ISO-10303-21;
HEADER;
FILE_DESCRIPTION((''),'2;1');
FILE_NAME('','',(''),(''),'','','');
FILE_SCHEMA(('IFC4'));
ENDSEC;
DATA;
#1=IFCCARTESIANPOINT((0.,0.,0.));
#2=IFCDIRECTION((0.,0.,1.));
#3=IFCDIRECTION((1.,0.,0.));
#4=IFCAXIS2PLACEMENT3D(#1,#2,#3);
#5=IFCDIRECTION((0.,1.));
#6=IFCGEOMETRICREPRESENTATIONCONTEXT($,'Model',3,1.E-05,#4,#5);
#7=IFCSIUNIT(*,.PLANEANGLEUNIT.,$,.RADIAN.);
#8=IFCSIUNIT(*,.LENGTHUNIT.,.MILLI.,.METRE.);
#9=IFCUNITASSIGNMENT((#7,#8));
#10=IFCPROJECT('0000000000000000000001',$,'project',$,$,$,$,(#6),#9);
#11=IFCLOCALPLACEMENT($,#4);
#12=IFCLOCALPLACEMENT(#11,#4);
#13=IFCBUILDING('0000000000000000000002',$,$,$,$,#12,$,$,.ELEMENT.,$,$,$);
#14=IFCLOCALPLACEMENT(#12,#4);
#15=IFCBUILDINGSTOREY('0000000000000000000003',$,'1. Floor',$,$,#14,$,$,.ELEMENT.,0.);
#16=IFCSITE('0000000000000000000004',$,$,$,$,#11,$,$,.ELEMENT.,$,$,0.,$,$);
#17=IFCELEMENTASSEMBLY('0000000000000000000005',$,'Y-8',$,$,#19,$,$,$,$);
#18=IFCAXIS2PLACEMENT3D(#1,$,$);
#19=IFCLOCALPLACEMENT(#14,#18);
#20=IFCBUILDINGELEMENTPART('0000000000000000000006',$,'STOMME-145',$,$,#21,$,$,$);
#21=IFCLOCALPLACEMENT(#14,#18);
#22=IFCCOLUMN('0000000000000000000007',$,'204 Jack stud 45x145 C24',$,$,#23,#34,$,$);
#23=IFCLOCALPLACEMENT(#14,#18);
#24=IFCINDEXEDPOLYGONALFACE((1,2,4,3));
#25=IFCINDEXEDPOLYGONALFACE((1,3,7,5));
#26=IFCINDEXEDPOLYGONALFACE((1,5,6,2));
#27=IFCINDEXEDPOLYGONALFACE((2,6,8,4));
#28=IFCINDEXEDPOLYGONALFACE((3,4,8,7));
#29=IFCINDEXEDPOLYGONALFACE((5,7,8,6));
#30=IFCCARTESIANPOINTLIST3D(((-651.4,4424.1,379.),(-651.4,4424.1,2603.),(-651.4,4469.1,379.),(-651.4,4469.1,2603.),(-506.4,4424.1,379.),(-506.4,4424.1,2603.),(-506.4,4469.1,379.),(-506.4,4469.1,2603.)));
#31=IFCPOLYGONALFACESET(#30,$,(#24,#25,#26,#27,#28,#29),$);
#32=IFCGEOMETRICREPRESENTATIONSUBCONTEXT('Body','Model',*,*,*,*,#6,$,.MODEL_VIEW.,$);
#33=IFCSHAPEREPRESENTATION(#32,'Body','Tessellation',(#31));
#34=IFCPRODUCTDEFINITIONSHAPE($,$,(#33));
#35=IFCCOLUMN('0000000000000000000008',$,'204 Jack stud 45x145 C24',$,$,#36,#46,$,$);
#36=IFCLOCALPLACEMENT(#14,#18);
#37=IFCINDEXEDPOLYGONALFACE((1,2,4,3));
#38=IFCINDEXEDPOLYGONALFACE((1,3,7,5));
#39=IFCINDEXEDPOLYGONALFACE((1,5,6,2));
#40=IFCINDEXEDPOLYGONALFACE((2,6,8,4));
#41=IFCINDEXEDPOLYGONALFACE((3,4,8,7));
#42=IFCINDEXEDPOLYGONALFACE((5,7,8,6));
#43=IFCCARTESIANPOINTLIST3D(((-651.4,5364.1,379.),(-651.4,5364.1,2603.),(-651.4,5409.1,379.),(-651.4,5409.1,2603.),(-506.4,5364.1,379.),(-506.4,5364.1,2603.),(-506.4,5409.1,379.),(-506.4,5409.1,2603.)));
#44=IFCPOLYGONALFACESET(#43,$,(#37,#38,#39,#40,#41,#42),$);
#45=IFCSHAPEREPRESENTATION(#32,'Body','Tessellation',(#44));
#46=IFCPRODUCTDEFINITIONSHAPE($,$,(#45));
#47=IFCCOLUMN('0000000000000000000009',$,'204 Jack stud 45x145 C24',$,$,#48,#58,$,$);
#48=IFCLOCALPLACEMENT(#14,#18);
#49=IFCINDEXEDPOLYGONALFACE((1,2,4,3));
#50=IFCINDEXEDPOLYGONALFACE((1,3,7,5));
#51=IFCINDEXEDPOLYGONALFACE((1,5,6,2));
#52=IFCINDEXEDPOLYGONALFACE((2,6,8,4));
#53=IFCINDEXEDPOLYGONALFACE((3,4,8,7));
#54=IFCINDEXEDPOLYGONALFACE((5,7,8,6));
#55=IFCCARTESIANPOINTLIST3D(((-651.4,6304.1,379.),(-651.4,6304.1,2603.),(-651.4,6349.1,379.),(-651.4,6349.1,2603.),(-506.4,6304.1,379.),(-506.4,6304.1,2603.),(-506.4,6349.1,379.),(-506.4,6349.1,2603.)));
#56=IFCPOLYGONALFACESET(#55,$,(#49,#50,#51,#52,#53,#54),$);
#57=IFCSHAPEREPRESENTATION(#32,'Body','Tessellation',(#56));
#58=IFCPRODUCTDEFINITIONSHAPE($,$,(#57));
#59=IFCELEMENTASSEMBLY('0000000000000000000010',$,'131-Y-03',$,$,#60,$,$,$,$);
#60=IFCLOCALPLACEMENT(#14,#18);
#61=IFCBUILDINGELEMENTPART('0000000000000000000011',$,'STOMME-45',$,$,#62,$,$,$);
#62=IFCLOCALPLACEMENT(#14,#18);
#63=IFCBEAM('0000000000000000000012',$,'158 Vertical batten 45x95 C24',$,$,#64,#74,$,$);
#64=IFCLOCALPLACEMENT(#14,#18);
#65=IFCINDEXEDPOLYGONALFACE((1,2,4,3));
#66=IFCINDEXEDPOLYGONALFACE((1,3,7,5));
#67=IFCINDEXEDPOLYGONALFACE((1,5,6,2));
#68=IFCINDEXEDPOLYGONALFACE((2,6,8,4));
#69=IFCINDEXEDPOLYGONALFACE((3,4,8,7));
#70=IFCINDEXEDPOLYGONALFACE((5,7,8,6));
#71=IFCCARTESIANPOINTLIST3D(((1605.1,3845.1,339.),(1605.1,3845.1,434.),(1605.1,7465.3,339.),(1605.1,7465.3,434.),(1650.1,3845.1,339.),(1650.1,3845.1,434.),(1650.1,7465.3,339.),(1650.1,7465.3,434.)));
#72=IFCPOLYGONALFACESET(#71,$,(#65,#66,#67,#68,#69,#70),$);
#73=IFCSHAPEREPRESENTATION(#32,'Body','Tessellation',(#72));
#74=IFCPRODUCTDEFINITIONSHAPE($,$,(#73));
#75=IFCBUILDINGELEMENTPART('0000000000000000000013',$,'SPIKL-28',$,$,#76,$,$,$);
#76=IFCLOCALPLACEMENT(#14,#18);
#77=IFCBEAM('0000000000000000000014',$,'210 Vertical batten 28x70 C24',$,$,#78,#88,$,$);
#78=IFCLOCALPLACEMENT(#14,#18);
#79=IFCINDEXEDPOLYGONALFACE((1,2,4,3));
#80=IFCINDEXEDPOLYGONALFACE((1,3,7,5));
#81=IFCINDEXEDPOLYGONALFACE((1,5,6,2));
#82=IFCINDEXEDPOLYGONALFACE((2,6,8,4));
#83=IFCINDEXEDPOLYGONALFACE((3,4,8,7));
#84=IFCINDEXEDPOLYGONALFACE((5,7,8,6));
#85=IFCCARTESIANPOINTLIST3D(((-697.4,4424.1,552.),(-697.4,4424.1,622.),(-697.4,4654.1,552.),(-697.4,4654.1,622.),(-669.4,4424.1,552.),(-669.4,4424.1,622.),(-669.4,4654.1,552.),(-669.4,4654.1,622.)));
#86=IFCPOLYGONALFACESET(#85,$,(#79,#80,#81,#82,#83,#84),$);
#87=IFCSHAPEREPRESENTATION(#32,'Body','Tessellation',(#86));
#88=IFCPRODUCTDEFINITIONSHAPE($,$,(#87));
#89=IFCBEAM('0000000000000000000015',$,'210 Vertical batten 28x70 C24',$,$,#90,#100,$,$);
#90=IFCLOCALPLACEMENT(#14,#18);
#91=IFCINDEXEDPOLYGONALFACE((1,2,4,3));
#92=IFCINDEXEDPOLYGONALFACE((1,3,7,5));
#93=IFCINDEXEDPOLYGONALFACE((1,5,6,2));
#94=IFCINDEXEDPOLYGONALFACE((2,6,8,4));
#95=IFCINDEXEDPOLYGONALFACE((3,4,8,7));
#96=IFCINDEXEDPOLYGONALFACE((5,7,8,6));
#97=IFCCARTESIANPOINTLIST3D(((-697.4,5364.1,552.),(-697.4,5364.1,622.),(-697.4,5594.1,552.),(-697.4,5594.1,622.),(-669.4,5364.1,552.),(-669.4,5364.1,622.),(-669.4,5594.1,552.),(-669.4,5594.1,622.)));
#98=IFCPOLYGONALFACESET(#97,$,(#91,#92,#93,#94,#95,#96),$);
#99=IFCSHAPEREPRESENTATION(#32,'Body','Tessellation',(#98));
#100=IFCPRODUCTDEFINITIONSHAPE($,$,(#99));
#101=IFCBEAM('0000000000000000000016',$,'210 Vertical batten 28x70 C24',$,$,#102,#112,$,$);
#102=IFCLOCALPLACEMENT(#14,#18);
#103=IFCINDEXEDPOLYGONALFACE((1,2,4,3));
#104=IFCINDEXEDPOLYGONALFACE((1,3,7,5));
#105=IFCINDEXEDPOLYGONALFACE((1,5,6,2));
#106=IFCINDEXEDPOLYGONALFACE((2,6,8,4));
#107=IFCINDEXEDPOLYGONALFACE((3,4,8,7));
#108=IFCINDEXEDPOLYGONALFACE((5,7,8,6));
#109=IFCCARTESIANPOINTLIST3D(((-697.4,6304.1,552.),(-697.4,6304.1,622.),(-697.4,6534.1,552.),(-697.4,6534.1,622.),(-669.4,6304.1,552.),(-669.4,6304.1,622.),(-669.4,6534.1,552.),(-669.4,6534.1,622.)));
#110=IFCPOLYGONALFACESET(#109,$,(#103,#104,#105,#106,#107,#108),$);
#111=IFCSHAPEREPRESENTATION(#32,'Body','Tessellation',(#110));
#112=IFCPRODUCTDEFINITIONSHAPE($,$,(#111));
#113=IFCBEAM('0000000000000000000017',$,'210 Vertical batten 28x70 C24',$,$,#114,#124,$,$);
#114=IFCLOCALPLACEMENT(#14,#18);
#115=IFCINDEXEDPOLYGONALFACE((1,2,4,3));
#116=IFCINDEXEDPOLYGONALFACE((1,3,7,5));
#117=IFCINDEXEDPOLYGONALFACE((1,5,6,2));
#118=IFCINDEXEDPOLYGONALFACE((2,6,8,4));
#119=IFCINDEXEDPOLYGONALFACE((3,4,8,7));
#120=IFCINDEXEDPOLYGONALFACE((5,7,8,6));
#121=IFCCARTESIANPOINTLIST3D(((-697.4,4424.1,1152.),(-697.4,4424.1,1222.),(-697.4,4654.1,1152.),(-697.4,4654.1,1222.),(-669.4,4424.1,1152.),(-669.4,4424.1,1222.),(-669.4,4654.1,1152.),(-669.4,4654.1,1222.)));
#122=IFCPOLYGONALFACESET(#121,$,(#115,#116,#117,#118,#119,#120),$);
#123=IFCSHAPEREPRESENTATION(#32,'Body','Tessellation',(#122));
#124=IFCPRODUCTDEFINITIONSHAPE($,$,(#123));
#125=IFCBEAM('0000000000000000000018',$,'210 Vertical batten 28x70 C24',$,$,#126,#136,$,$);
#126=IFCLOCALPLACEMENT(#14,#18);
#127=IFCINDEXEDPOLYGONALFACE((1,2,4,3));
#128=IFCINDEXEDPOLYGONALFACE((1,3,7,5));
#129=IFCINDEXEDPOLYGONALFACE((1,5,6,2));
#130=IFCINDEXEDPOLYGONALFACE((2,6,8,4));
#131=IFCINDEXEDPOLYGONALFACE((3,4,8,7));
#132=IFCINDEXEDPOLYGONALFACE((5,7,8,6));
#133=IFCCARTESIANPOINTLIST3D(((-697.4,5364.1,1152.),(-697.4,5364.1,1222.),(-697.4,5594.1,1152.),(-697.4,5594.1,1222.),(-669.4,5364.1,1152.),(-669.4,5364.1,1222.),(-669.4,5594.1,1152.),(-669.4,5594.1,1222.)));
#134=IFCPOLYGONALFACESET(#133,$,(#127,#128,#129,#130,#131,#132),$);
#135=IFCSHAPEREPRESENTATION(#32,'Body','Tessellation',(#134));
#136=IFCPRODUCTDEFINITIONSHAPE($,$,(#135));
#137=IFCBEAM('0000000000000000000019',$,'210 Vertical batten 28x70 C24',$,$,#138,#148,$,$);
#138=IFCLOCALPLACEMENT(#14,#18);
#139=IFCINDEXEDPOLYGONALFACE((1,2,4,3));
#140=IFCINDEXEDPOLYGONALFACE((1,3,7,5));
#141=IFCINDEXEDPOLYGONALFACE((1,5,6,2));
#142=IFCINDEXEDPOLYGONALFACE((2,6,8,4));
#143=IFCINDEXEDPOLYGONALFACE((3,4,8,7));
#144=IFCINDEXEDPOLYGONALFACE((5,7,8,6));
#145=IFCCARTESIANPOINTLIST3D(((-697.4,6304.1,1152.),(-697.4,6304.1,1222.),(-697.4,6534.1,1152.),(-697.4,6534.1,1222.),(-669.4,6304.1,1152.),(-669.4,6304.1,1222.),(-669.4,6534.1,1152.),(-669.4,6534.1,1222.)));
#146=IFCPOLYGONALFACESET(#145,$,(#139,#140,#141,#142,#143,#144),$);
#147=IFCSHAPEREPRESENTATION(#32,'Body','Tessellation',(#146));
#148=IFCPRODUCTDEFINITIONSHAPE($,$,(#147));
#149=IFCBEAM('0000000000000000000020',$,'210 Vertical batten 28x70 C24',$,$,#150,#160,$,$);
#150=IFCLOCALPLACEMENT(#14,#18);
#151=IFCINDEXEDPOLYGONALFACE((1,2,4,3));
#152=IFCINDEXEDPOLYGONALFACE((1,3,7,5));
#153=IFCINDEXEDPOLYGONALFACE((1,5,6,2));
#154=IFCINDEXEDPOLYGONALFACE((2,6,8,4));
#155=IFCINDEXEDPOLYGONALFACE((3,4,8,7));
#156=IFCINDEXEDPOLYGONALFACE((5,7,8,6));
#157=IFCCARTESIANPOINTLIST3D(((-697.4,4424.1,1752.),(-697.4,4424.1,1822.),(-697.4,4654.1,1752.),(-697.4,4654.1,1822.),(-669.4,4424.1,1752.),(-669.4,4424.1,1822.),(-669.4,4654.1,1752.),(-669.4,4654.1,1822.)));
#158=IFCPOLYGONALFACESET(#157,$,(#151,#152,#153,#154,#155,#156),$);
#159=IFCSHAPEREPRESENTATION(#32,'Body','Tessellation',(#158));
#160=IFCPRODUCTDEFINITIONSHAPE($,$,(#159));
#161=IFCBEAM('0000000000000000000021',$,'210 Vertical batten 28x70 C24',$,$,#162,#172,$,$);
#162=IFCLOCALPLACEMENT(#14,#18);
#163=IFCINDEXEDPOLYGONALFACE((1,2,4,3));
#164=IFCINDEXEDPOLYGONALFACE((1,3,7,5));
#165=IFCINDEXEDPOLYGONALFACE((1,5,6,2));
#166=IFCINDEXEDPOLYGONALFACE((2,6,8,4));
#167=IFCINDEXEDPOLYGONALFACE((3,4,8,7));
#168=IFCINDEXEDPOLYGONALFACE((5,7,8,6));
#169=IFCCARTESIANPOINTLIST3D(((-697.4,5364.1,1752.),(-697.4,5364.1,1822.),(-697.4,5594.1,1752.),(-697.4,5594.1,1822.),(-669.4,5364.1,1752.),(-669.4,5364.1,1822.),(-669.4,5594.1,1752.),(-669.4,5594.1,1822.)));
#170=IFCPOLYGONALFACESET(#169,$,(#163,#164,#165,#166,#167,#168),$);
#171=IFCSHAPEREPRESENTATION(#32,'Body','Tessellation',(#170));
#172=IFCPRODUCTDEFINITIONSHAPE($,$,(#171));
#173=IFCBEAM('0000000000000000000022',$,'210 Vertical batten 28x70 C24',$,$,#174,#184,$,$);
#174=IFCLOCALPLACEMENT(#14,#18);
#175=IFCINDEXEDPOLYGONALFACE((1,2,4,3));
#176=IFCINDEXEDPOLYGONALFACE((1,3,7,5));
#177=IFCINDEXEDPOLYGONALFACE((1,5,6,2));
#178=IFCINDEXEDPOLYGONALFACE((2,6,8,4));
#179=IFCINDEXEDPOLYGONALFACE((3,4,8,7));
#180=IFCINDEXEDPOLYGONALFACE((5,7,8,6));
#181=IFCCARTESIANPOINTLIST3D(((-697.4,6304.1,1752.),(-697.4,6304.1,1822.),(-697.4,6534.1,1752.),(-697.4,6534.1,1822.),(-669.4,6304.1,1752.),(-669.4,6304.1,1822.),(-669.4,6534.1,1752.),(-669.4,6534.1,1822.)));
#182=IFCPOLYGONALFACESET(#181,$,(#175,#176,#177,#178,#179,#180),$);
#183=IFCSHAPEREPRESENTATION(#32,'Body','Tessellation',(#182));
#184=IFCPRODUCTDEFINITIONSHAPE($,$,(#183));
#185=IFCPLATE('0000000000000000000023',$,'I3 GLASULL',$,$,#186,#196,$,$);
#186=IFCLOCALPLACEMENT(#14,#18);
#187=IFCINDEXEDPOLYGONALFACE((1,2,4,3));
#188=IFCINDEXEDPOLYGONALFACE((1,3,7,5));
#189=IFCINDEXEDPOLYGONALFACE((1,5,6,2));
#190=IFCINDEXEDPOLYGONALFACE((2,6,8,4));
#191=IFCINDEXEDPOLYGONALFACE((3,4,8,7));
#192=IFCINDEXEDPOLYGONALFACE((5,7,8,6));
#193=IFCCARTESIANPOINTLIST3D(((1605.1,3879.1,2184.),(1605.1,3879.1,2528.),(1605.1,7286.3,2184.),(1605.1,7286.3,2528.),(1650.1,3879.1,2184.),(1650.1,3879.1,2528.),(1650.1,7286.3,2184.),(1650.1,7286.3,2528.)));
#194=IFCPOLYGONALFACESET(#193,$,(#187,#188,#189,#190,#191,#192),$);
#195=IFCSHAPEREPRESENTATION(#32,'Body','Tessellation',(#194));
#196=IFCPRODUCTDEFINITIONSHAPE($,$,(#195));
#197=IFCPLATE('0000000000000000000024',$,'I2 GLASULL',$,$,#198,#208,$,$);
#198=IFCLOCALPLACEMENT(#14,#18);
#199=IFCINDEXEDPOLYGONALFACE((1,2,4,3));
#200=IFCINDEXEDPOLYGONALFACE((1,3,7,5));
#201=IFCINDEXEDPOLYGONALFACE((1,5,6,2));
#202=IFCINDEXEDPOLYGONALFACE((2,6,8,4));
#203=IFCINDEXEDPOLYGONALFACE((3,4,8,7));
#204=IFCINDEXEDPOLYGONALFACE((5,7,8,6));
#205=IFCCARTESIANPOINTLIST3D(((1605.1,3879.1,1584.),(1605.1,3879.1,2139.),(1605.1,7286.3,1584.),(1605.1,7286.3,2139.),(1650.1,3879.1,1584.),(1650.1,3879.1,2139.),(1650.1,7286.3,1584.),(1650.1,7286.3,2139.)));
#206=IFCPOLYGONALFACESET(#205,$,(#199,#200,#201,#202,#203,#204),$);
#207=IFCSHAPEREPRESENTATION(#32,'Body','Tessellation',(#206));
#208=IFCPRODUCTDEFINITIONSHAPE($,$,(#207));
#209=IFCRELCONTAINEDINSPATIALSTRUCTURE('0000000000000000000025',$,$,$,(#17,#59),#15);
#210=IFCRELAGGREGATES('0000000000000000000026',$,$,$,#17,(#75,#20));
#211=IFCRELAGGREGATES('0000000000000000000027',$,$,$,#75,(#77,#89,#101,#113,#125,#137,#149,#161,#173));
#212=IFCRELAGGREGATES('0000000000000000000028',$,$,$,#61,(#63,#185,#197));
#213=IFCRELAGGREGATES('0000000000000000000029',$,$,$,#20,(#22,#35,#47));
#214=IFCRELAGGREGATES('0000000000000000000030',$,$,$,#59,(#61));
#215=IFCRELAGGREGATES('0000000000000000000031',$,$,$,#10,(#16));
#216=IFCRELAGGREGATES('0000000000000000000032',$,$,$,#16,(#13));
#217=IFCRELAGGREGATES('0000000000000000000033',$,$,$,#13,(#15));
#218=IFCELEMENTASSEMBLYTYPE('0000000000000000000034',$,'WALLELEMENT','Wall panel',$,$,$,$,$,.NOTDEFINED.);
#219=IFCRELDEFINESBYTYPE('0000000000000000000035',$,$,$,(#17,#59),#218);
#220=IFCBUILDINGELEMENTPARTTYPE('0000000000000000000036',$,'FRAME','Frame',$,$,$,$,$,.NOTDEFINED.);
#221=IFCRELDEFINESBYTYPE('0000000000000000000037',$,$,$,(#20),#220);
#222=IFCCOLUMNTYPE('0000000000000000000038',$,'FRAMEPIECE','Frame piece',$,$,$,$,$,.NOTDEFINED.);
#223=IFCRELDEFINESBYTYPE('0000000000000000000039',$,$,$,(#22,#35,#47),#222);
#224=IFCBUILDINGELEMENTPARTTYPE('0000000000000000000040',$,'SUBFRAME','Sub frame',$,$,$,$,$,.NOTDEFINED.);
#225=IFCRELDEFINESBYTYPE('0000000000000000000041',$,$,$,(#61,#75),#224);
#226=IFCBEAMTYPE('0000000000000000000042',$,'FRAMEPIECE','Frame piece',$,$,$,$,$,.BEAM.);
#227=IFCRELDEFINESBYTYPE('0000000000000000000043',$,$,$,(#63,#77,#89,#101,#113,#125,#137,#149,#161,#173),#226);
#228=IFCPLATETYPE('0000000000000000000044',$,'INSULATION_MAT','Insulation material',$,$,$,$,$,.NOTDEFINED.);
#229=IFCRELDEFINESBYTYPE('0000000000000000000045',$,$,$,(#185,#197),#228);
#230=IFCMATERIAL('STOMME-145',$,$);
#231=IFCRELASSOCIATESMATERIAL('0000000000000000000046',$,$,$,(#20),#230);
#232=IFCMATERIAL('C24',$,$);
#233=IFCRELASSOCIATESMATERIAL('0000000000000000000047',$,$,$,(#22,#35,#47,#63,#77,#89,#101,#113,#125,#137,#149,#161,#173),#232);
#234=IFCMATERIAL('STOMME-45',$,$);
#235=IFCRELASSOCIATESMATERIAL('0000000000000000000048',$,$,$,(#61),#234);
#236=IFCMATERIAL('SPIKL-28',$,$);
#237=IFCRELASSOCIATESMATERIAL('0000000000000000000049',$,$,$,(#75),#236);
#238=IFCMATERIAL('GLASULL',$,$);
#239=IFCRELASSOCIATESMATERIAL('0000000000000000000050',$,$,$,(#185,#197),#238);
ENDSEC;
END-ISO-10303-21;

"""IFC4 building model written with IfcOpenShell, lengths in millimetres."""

from ifc_helpers import new_model, si_unit, direction, frame, origin_with_axes, origin_2d_with_axis, place, context, subcontext, project, spatial, rectangle, extrude, material, type_object, element, aggregate, save


model = new_model("IFC4")

# Units and contexts
model_context = context("Model", 3, precision=1e-05, world=origin_with_axes(), true_north=direction((0.0, 1.0)))
body_context = subcontext(model_context, "Body", "Model", "MODEL_VIEW")
ifc_project = project(units=[si_unit("PLANEANGLEUNIT", "RADIAN"), si_unit("LENGTHUNIT", "METRE", prefix="MILLI")], contexts=[model_context])

# Site, building, storey
site_placement = place(None, origin_with_axes())
site = spatial("IfcSite", under=ifc_project, at=site_placement, CompositionType="ELEMENT", RefElevation=0.0)
building_placement = place(site_placement, origin_with_axes())
building = spatial("IfcBuilding", under=site, at=building_placement, CompositionType="ELEMENT")
storey_placement = place(building_placement, origin_with_axes())
storey = spatial("IfcBuildingStorey", under=building, at=storey_placement, Name="1. Floor", CompositionType="ELEMENT", Elevation=0.0)

# Element assembly, building element part, columns
element_assembly_type = type_object("IfcElementAssemblyType", Name="WALLELEMENT", Description="Wall panel", PredefinedType="NOTDEFINED")
assembly_1_placement = place(storey_placement, origin_with_axes())
assembly_1 = element("IfcElementAssembly", 1, at=assembly_1_placement, inside=storey, type_object=element_assembly_type, Name="Y-8")
ifc_material_1 = material(Name="STOMME-145")
building_element_part_type_1 = type_object("IfcBuildingElementPartType", Name="FRAME", Description="Frame", PredefinedType="NOTDEFINED")
building_element_part_1_placement = place(storey_placement, origin_with_axes())
building_element_part_1 = element("IfcBuildingElementPart", 2, at=building_element_part_1_placement, type_object=building_element_part_type_1, material=ifc_material_1, Name="STOMME-145")
ifc_material_2 = material(Name="C24")
column_type = type_object("IfcColumnType", Name="FRAMEPIECE", Description="Frame piece", PredefinedType="NOTDEFINED")
column_1_placement = place(storey_placement, frame((-578.9, 4446.6, 379.0), z_axis=(0.0, 0.0, 1.0), x_axis=(0.0, 1.0, 0.0)))
column_1 = element("IfcColumn", 3, at=column_1_placement, type_object=column_type, material=ifc_material_2, Name="204 Jack stud 45x145 C24", context=body_context, shape_type="SweptSolid", body=[
    extrude(rectangle(XDim=45.0, YDim=145.0, at=origin_2d_with_axis()), origin_with_axes(), (0.0, 0.0, 1.0), 2224.0),
])
column_2_placement = place(storey_placement, frame((-578.9, 5386.6, 379.0), z_axis=(0.0, 0.0, 1.0), x_axis=(0.0, 1.0, 0.0)))
column_2 = element("IfcColumn", 4, at=column_2_placement, type_object=column_type, material=ifc_material_2, Name="204 Jack stud 45x145 C24", context=body_context, shape_type="SweptSolid", body=[
    extrude(rectangle(XDim=45.0, YDim=145.0, at=origin_2d_with_axis()), origin_with_axes(), (0.0, 0.0, 1.0), 2224.0),
])
column_3_placement = place(storey_placement, frame((-578.9, 6326.6, 379.0), z_axis=(0.0, 0.0, 1.0), x_axis=(0.0, 1.0, 0.0)))
column_3 = element("IfcColumn", 5, at=column_3_placement, type_object=column_type, material=ifc_material_2, Name="204 Jack stud 45x145 C24", context=body_context, shape_type="SweptSolid", body=[
    extrude(rectangle(XDim=45.0, YDim=145.0, at=origin_2d_with_axis()), origin_with_axes(), (0.0, 0.0, 1.0), 2224.0),
])

# Element assembly, building element part, beam
assembly_2_placement = place(storey_placement, origin_with_axes())
assembly_2 = element("IfcElementAssembly", 6, at=assembly_2_placement, inside=storey, type_object=element_assembly_type, Name="131-Y-03")
ifc_material_3 = material(Name="STOMME-45")
building_element_part_type_2 = type_object("IfcBuildingElementPartType", Name="SUBFRAME", Description="Sub frame", PredefinedType="NOTDEFINED")
building_element_part_2_placement = place(storey_placement, origin_with_axes())
building_element_part_2 = element("IfcBuildingElementPart", 7, at=building_element_part_2_placement, type_object=building_element_part_type_2, material=ifc_material_3, Name="STOMME-45")
beam_type = type_object("IfcBeamType", Name="FRAMEPIECE", Description="Frame piece", PredefinedType="BEAM")
beam_1_placement = place(storey_placement, frame((1627.6, 3845.1, 386.5), z_axis=(0.0, 1.0, 0.0), x_axis=(-1.0, 0.0, 0.0)))
beam_1 = element("IfcBeam", 8, at=beam_1_placement, type_object=beam_type, material=ifc_material_2, Name="158 Vertical batten 45x95 C24", context=body_context, shape_type="SweptSolid", body=[
    extrude(rectangle(XDim=45.0, YDim=95.0, at=origin_2d_with_axis()), origin_with_axes(), (0.0, 0.0, 1.0), 3620.2),
])

# Building element part
ifc_material_4 = material(Name="SPIKL-28")
building_element_part_3_placement = place(storey_placement, origin_with_axes())
building_element_part_3 = element("IfcBuildingElementPart", 9, at=building_element_part_3_placement, type_object=building_element_part_type_2, material=ifc_material_4, Name="SPIKL-28")
aggregate(assembly_1, [building_element_part_3, building_element_part_1])

# Beams
beam_2_placement = place(storey_placement, frame((-683.4, 4424.1, 587.0), z_axis=(0.0, 1.0, 0.0), x_axis=(-1.0, 0.0, 0.0)))
beam_2 = element("IfcBeam", 10, at=beam_2_placement, type_object=beam_type, material=ifc_material_2, Name="210 Vertical batten 28x70 C24", context=body_context, shape_type="SweptSolid", body=[
    extrude(rectangle(XDim=28.0, YDim=70.0, at=origin_2d_with_axis()), origin_with_axes(), (0.0, 0.0, 1.0), 230.0),
])
beam_3_placement = place(storey_placement, frame((-683.4, 5364.1, 587.0), z_axis=(0.0, 1.0, 0.0), x_axis=(-1.0, 0.0, 0.0)))
beam_3 = element("IfcBeam", 11, at=beam_3_placement, type_object=beam_type, material=ifc_material_2, Name="210 Vertical batten 28x70 C24", context=body_context, shape_type="SweptSolid", body=[
    extrude(rectangle(XDim=28.0, YDim=70.0, at=origin_2d_with_axis()), origin_with_axes(), (0.0, 0.0, 1.0), 230.0),
])
beam_4_placement = place(storey_placement, frame((-683.4, 6304.1, 587.0), z_axis=(0.0, 1.0, 0.0), x_axis=(-1.0, 0.0, 0.0)))
beam_4 = element("IfcBeam", 12, at=beam_4_placement, type_object=beam_type, material=ifc_material_2, Name="210 Vertical batten 28x70 C24", context=body_context, shape_type="SweptSolid", body=[
    extrude(rectangle(XDim=28.0, YDim=70.0, at=origin_2d_with_axis()), origin_with_axes(), (0.0, 0.0, 1.0), 230.0),
])
beam_5_placement = place(storey_placement, frame((-683.4, 4424.1, 1187.0), z_axis=(0.0, 1.0, 0.0), x_axis=(-1.0, 0.0, 0.0)))
beam_5 = element("IfcBeam", 13, at=beam_5_placement, type_object=beam_type, material=ifc_material_2, Name="210 Vertical batten 28x70 C24", context=body_context, shape_type="SweptSolid", body=[
    extrude(rectangle(XDim=28.0, YDim=70.0, at=origin_2d_with_axis()), origin_with_axes(), (0.0, 0.0, 1.0), 230.0),
])
beam_6_placement = place(storey_placement, frame((-683.4, 5364.1, 1187.0), z_axis=(0.0, 1.0, 0.0), x_axis=(-1.0, 0.0, 0.0)))
beam_6 = element("IfcBeam", 14, at=beam_6_placement, type_object=beam_type, material=ifc_material_2, Name="210 Vertical batten 28x70 C24", context=body_context, shape_type="SweptSolid", body=[
    extrude(rectangle(XDim=28.0, YDim=70.0, at=origin_2d_with_axis()), origin_with_axes(), (0.0, 0.0, 1.0), 230.0),
])
beam_7_placement = place(storey_placement, frame((-683.4, 6304.1, 1187.0), z_axis=(0.0, 1.0, 0.0), x_axis=(-1.0, 0.0, 0.0)))
beam_7 = element("IfcBeam", 15, at=beam_7_placement, type_object=beam_type, material=ifc_material_2, Name="210 Vertical batten 28x70 C24", context=body_context, shape_type="SweptSolid", body=[
    extrude(rectangle(XDim=28.0, YDim=70.0, at=origin_2d_with_axis()), origin_with_axes(), (0.0, 0.0, 1.0), 230.0),
])
beam_8_placement = place(storey_placement, frame((-683.4, 4424.1, 1787.0), z_axis=(0.0, 1.0, 0.0), x_axis=(-1.0, 0.0, 0.0)))
beam_8 = element("IfcBeam", 16, at=beam_8_placement, type_object=beam_type, material=ifc_material_2, Name="210 Vertical batten 28x70 C24", context=body_context, shape_type="SweptSolid", body=[
    extrude(rectangle(XDim=28.0, YDim=70.0, at=origin_2d_with_axis()), origin_with_axes(), (0.0, 0.0, 1.0), 230.0),
])
beam_9_placement = place(storey_placement, frame((-683.4, 5364.1, 1787.0), z_axis=(0.0, 1.0, 0.0), x_axis=(-1.0, 0.0, 0.0)))
beam_9 = element("IfcBeam", 17, at=beam_9_placement, type_object=beam_type, material=ifc_material_2, Name="210 Vertical batten 28x70 C24", context=body_context, shape_type="SweptSolid", body=[
    extrude(rectangle(XDim=28.0, YDim=70.0, at=origin_2d_with_axis()), origin_with_axes(), (0.0, 0.0, 1.0), 230.0),
])
beam_10_placement = place(storey_placement, frame((-683.4, 6304.1, 1787.0), z_axis=(0.0, 1.0, 0.0), x_axis=(-1.0, 0.0, 0.0)))
beam_10 = element("IfcBeam", 18, at=beam_10_placement, type_object=beam_type, material=ifc_material_2, Name="210 Vertical batten 28x70 C24", context=body_context, shape_type="SweptSolid", body=[
    extrude(rectangle(XDim=28.0, YDim=70.0, at=origin_2d_with_axis()), origin_with_axes(), (0.0, 0.0, 1.0), 230.0),
])
aggregate(building_element_part_3, [beam_2, beam_3, beam_4, beam_5, beam_6, beam_7, beam_8, beam_9, beam_10])

# Plates
ifc_material_5 = material(Name="GLASULL")
plate_type_1 = type_object("IfcPlateType", Name="INSULATION_MAT", Description="Insulation material", PredefinedType="NOTDEFINED")
plate_1_placement = place(storey_placement, frame((1605.1, 5582.7, 2356.0), z_axis=(-1.0, 0.0, 0.0), x_axis=(0.0, -1.0, 0.0)))
plate_1 = element("IfcPlate", 19, at=plate_1_placement, type_object=plate_type_1, material=ifc_material_5, Name="I3 GLASULL", context=body_context, shape_type="SweptSolid", body=[
    extrude(rectangle(XDim=45.0, YDim=3407.2, at=origin_2d_with_axis()), frame((0.0, -172.0, -22.5), z_axis=(0.0, 1.0, 0.0), x_axis=(0.0, 0.0, 1.0)), (0.0, 0.0, 1.0), 344.0),
])
plate_2_placement = place(storey_placement, frame((1605.1, 5582.7, 1861.5), z_axis=(-1.0, 0.0, 0.0), x_axis=(0.0, -1.0, 0.0)))
plate_2 = element("IfcPlate", 20, at=plate_2_placement, type_object=plate_type_1, material=ifc_material_5, Name="I2 GLASULL", context=body_context, shape_type="SweptSolid", body=[
    extrude(rectangle(XDim=45.0, YDim=3407.2, at=origin_2d_with_axis()), frame((0.0, -277.5, -22.5), z_axis=(0.0, 1.0, 0.0), x_axis=(0.0, 0.0, 1.0)), (0.0, 0.0, 1.0), 555.0),
])
aggregate(building_element_part_2, [beam_1, plate_1, plate_2])
aggregate(building_element_part_1, [column_1, column_2, column_3])

aggregate(assembly_2, [building_element_part_2])

save(model, "model.ifc")
